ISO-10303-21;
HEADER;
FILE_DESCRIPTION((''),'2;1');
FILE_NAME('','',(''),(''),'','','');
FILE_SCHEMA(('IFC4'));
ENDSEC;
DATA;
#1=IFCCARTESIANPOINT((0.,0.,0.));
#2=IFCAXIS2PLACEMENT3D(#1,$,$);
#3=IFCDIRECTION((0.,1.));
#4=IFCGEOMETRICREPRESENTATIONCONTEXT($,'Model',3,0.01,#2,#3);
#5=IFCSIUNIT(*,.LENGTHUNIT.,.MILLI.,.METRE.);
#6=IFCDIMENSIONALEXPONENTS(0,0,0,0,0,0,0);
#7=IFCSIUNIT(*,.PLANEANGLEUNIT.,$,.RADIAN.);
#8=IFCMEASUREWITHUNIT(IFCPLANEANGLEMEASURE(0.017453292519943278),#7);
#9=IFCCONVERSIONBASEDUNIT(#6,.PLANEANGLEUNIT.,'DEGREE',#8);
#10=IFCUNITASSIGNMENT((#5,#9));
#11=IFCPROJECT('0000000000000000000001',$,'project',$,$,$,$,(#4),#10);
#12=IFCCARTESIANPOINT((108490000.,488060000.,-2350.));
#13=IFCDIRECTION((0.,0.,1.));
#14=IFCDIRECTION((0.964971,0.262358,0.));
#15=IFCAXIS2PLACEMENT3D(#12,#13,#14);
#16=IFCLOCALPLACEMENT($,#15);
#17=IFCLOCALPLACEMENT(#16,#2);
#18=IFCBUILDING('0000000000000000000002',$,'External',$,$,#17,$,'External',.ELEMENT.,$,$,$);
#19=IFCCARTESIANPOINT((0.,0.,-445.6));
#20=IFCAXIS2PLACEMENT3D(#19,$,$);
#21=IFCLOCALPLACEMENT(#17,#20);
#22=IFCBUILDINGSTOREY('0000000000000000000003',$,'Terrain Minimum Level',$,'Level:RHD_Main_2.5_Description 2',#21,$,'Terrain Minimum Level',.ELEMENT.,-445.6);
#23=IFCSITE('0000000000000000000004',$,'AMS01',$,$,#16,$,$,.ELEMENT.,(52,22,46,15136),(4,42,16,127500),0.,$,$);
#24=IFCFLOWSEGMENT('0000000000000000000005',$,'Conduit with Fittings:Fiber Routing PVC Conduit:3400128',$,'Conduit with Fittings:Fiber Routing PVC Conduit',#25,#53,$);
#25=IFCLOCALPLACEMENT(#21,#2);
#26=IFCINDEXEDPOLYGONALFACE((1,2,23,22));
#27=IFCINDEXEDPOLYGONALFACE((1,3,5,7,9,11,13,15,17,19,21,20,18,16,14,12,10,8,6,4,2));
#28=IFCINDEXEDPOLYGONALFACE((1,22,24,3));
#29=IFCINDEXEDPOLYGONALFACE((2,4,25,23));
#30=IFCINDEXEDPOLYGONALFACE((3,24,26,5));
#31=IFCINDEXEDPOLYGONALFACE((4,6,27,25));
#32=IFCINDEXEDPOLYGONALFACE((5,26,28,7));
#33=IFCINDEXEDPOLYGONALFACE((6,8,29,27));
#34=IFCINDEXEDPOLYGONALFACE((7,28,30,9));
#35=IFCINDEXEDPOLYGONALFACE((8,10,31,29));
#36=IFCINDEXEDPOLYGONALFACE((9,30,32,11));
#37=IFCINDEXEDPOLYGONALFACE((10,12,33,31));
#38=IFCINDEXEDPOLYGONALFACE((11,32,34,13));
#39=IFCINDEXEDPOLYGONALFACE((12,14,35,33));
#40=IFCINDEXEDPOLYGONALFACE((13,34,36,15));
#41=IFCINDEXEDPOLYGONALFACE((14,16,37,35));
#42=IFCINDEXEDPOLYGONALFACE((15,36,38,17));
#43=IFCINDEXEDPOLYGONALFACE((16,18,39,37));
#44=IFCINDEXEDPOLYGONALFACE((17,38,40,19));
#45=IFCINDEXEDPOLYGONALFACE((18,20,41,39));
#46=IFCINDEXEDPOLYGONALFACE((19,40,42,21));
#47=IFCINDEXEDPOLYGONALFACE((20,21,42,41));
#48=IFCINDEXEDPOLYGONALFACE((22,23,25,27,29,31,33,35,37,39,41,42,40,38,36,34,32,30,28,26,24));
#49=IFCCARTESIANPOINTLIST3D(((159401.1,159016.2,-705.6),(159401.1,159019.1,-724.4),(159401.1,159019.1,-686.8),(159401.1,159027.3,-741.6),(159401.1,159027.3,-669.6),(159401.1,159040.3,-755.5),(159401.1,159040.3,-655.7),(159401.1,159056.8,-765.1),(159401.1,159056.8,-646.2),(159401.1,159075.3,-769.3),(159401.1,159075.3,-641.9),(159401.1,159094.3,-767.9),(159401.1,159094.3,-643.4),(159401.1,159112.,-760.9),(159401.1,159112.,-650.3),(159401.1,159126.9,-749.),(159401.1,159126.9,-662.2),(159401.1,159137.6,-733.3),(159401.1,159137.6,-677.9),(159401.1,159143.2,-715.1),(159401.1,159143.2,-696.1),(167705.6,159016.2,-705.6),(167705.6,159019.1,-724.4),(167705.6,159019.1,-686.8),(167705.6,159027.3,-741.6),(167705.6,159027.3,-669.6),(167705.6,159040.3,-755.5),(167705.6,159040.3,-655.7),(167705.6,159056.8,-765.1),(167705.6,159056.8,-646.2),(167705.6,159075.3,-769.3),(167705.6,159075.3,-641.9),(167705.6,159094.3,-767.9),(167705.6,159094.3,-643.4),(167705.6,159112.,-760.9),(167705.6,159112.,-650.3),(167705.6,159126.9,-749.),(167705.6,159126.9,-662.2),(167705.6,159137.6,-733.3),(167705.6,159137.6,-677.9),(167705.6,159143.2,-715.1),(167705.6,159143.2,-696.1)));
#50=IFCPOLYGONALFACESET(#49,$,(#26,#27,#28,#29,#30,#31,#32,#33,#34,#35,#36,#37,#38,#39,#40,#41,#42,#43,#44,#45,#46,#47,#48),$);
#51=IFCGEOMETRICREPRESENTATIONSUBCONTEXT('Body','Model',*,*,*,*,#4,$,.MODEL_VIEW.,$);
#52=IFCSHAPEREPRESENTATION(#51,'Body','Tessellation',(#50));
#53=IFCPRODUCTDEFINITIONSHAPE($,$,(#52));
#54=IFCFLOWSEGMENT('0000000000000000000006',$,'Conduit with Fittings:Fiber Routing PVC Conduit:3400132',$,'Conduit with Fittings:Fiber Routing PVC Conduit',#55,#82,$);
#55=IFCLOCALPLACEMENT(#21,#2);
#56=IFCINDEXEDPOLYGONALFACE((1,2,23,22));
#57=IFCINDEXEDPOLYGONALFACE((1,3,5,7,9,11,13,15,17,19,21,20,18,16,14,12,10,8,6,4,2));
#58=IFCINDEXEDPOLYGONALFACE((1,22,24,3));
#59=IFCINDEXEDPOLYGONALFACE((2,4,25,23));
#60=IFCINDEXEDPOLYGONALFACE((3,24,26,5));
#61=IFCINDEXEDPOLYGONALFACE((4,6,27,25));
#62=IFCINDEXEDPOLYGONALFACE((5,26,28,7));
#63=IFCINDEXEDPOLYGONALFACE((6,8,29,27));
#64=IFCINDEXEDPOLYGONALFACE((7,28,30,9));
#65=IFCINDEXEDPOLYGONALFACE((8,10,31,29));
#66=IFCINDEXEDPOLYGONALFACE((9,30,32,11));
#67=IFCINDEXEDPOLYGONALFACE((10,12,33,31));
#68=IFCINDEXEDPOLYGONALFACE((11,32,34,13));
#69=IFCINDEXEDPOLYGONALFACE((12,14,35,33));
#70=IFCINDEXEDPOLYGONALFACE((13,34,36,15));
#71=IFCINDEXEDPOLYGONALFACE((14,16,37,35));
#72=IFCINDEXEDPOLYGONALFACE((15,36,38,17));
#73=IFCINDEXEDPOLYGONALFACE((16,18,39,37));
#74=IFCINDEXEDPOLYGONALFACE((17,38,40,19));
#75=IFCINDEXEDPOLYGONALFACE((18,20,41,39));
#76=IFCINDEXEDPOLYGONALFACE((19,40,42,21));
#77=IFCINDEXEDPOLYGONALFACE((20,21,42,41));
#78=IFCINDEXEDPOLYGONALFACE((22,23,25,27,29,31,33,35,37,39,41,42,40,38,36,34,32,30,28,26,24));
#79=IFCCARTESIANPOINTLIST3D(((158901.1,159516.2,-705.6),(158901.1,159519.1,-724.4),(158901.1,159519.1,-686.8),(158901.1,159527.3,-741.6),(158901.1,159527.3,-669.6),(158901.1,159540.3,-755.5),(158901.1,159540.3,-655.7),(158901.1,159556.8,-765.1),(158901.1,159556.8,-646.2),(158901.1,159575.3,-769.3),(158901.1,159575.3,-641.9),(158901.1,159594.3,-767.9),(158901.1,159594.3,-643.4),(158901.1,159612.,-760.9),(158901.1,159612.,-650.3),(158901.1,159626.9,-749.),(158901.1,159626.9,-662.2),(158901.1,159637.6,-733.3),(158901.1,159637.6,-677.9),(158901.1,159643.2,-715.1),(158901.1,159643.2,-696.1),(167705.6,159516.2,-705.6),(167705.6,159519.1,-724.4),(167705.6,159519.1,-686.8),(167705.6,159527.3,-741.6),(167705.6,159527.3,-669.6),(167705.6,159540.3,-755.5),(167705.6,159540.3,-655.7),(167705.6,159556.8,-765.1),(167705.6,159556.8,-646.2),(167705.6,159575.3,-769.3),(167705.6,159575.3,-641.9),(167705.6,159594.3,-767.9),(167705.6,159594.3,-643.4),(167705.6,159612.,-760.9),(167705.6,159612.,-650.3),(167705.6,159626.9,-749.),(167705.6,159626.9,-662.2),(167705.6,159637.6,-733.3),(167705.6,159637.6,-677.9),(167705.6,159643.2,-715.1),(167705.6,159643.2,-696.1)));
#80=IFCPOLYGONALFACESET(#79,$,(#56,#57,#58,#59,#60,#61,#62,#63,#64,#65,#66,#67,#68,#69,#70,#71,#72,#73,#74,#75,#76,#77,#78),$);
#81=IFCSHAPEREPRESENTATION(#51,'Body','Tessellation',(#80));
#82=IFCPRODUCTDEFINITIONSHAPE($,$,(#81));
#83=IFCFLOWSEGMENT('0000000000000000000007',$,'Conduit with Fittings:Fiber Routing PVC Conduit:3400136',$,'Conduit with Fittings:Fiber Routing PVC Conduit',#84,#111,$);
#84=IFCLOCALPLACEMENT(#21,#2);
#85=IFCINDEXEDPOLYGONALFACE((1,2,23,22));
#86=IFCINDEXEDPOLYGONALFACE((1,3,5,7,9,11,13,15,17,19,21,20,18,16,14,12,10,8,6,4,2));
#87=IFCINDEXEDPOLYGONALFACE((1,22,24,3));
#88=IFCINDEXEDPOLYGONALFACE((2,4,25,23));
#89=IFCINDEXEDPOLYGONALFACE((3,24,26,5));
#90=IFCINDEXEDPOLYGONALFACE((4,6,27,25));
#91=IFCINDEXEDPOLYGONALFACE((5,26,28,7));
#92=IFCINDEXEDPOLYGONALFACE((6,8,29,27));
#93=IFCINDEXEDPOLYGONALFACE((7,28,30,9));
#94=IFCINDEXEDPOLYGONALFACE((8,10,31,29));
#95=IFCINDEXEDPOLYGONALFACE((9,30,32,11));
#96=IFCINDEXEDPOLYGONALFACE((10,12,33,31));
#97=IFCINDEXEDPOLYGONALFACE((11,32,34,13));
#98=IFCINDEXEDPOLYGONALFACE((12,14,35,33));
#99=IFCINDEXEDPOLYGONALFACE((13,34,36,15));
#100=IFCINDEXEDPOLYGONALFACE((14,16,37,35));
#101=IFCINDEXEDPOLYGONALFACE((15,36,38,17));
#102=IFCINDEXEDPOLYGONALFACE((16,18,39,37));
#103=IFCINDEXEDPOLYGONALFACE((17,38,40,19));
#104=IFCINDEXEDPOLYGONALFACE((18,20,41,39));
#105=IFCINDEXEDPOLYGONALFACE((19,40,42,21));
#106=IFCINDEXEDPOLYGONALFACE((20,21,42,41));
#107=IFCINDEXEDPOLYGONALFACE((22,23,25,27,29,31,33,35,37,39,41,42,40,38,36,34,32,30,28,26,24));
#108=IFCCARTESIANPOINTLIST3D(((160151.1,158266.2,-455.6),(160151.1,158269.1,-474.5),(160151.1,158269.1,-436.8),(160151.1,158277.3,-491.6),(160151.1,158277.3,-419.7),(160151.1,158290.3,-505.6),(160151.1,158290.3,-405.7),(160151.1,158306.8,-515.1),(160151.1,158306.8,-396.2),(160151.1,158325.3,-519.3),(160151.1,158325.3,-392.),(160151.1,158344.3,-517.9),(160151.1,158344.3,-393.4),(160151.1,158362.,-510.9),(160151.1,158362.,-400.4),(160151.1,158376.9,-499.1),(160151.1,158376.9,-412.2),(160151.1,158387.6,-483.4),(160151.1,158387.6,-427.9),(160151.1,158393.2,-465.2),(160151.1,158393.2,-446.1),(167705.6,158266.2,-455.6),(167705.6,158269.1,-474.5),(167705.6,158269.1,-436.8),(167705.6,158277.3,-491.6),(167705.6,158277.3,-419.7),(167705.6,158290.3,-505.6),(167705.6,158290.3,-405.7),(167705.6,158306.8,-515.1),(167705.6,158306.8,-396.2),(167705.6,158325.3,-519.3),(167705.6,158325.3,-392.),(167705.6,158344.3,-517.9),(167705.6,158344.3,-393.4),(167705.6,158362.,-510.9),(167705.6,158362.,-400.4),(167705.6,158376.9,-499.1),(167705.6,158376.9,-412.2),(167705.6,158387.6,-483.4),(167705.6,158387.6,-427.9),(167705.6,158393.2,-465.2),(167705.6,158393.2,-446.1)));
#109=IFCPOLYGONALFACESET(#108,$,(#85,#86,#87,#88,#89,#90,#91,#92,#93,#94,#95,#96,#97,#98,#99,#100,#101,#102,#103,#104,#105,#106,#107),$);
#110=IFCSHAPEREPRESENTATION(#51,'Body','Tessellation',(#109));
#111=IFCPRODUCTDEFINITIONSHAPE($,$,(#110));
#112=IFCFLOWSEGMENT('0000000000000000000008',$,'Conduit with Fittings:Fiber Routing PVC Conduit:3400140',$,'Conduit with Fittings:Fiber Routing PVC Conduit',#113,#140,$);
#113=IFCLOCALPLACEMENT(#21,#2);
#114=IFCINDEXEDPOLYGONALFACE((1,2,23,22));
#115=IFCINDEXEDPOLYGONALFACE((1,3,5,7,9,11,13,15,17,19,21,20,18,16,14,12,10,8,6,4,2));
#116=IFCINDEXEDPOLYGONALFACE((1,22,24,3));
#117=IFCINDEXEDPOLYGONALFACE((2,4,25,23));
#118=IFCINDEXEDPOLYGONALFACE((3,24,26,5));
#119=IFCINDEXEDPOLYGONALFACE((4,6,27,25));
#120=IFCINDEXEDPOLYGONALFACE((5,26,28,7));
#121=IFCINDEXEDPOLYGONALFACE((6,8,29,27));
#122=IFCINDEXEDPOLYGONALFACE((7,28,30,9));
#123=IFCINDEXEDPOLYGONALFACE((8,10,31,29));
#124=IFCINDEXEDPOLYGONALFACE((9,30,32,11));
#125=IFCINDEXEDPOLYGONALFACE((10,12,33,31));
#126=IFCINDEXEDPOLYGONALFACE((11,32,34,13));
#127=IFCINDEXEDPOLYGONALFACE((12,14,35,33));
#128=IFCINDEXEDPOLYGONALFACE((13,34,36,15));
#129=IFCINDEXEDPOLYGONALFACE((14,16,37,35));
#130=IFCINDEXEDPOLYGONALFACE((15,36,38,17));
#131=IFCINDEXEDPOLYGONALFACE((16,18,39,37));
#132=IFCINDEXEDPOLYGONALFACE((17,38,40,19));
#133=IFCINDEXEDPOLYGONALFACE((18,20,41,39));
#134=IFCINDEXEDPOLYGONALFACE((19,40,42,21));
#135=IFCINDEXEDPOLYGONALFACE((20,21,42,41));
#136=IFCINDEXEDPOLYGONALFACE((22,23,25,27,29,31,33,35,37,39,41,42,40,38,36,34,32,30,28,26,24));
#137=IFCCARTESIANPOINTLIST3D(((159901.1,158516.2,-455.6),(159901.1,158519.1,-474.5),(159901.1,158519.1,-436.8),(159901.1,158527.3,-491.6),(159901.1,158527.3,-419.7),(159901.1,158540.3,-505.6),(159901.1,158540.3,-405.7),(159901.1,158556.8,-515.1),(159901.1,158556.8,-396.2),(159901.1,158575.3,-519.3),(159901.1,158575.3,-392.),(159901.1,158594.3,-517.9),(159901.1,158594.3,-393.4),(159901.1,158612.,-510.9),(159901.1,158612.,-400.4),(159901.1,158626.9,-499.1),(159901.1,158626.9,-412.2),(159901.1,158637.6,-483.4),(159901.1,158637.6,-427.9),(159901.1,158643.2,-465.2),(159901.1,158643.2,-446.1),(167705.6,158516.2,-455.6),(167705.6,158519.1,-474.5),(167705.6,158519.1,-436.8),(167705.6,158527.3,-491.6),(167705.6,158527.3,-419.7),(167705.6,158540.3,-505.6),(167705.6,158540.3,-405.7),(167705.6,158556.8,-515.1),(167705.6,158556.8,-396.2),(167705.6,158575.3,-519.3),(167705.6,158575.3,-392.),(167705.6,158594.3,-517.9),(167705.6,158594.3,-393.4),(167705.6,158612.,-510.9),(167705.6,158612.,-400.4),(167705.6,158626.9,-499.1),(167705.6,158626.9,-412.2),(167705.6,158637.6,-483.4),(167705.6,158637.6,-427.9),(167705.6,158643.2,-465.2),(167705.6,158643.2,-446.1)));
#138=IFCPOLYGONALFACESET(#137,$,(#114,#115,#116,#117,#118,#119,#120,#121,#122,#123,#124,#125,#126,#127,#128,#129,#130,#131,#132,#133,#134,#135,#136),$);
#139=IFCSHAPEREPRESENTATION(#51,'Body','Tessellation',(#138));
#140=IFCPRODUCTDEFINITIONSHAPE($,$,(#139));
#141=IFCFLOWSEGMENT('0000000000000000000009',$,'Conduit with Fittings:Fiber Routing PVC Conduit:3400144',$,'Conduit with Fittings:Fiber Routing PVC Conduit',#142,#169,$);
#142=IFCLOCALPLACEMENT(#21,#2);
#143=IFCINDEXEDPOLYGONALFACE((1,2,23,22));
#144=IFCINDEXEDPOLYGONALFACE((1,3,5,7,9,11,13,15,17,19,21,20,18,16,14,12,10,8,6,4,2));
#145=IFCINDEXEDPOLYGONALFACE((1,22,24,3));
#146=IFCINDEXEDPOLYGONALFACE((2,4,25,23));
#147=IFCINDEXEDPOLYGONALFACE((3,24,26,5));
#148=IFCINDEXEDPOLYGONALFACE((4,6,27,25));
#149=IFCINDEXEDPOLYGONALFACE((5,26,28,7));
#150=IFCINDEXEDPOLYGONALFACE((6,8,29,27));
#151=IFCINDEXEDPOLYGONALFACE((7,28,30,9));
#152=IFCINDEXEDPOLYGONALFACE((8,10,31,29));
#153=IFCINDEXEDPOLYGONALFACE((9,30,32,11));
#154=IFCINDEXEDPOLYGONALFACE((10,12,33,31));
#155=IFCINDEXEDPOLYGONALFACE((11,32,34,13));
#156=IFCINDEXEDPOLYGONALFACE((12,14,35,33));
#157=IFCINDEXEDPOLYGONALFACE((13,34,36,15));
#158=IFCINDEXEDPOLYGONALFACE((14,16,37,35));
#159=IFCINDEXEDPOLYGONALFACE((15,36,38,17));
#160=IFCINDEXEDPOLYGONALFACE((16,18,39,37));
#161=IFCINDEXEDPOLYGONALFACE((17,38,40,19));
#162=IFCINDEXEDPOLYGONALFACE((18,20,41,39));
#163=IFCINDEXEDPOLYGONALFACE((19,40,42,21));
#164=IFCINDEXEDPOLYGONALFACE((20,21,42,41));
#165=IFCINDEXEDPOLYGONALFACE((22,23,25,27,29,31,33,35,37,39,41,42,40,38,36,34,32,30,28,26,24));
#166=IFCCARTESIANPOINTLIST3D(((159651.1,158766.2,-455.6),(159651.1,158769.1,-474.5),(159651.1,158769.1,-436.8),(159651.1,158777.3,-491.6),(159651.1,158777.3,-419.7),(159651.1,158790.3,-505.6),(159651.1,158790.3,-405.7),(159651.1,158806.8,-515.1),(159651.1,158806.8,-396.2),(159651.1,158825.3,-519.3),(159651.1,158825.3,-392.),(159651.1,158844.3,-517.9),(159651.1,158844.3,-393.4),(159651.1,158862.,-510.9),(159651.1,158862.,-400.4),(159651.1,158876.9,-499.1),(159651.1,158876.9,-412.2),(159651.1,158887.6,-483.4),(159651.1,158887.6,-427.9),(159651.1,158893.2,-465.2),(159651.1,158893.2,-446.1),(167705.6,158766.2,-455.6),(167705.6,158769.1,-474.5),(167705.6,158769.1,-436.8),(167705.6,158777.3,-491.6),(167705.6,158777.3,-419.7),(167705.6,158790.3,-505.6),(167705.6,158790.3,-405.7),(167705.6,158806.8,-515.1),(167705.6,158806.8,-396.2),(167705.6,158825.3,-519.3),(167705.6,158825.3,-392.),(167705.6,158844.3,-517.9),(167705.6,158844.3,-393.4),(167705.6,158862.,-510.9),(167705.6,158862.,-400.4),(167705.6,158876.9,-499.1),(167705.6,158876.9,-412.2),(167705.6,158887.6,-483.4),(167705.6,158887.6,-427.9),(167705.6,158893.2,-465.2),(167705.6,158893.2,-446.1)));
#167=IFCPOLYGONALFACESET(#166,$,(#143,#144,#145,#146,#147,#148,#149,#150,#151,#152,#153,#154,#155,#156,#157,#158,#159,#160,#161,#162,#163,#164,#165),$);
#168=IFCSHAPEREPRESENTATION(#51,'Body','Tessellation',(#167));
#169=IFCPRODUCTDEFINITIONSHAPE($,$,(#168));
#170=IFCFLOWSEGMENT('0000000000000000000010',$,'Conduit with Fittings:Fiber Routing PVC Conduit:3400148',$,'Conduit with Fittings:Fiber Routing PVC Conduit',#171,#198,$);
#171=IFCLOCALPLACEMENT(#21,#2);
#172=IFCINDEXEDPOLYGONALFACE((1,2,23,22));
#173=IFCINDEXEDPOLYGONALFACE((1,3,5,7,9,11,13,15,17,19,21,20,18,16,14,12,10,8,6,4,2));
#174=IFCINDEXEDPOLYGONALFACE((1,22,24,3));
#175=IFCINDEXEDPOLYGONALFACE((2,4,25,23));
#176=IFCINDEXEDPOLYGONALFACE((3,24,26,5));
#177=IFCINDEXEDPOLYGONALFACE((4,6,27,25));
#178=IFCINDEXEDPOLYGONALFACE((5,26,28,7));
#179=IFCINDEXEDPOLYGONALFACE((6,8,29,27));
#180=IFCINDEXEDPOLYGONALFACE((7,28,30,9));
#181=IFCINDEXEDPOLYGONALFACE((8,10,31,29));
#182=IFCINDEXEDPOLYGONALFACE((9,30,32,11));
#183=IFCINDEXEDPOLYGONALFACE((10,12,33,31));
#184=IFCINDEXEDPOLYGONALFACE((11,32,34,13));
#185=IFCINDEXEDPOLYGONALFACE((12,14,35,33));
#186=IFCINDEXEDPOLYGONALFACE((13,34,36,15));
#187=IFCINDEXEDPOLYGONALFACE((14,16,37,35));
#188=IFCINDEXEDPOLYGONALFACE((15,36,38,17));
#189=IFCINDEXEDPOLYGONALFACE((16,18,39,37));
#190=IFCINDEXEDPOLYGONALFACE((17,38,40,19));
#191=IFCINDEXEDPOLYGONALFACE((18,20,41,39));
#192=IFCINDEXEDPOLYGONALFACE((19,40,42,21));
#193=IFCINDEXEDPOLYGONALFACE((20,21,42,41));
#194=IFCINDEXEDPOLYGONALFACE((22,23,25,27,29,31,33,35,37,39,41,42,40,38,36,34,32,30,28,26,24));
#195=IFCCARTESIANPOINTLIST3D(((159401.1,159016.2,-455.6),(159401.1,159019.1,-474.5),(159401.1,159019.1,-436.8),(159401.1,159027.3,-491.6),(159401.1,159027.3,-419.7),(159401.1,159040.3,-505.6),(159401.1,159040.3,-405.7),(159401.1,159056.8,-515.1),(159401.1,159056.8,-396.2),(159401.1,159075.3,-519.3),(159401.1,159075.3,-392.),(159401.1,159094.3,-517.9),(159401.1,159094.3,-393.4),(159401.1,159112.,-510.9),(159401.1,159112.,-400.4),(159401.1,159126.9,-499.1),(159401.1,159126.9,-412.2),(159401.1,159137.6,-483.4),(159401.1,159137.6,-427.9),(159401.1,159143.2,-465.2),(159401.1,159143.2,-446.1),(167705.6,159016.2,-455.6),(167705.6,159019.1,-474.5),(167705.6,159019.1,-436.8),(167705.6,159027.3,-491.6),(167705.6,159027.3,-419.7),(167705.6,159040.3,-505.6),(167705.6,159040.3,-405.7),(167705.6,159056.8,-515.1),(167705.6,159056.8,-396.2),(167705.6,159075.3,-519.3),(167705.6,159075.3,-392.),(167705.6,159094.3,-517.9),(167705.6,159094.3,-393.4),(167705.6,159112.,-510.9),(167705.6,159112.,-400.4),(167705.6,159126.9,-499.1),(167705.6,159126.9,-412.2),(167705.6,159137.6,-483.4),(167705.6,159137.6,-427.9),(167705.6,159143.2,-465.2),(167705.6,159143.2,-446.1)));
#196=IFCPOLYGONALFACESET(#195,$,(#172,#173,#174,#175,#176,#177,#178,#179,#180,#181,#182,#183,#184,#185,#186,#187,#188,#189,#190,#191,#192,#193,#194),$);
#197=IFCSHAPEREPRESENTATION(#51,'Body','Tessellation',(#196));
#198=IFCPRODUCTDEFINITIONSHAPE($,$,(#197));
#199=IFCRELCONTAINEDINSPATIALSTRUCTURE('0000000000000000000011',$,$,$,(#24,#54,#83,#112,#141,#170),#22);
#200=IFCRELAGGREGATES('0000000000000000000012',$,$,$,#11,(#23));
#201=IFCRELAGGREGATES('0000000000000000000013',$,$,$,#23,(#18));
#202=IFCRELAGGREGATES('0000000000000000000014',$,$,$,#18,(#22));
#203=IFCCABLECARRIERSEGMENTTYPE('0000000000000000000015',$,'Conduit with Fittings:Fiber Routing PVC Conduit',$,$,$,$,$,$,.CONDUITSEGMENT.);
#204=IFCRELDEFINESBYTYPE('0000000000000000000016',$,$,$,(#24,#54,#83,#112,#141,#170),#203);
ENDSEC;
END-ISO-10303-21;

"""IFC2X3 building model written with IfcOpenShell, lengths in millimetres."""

from ifc_helpers import new_model, entity, si_unit, converted_unit, direction, frame, frame_2d, origin, place, context, subcontext, project, spatial, circle, extrude, type_object, element, save


model = new_model("IFC2X3")

# Units and contexts
model_context = context("Model", 3, precision=0.01, world=origin(), true_north=direction((0.0, 1.0)))
body_context = subcontext(model_context, "Body", "Model", "MODEL_VIEW")
ifc_project = project(units=[si_unit("LENGTHUNIT", "METRE", prefix="MILLI"), converted_unit("PLANEANGLEUNIT", "DEGREE", entity("IfcPlaneAngleMeasure", 0.017453292519943278), si_unit("PLANEANGLEUNIT", "RADIAN"), dimensions=[0, 0, 0, 0, 0, 0, 0])], contexts=[model_context])

# Site, building, storey
site_placement = place(None, frame((108490000.0, 488060000.0, -2350.0), z_axis=(0.0, 0.0, 1.0), x_axis=(0.964971, 0.262358, 0.0)))
site = spatial("IfcSite", under=ifc_project, at=site_placement, Name="AMS01", CompositionType="ELEMENT", RefLatitude=(52, 22, 46, 15136), RefLongitude=(4, 42, 16, 127500), RefElevation=0.0)
building_placement = place(site_placement, origin())
building = spatial("IfcBuilding", under=site, at=building_placement, Name="External", LongName="External", CompositionType="ELEMENT")
storey_placement = place(building_placement, frame((0.0, 0.0, -445.6)))
storey = spatial("IfcBuildingStorey", under=building, at=storey_placement, Name="Terrain Minimum Level", ObjectType="Level:RHD_Main_2.5_Description 2", LongName="Terrain Minimum Level", CompositionType="ELEMENT", Elevation=-445.6)

# Flow segments
cable_carrier_segment_type = type_object("IfcCableCarrierSegmentType", Name="Conduit with Fittings:Fiber Routing PVC Conduit", PredefinedType="CONDUITSEGMENT")
flow_segment_1_placement = place(storey_placement, origin())
element("IfcFlowSegment", 1, at=flow_segment_1_placement, inside=storey, type_object=cable_carrier_segment_type, Name="Conduit with Fittings:Fiber Routing PVC Conduit:3400128", ObjectType="Conduit with Fittings:Fiber Routing PVC Conduit", context=body_context, shape_type="SweptSolid", body=[
    extrude(circle(Radius=63.9, at=frame_2d((0.0, 0.0), x_axis=(1.0, 0.0))), frame((159401.1, 159080.1, -705.6), z_axis=(1.0, 0.0, 0.0), x_axis=(0.0, -1.0, 0.0)), (0.0, 0.0, 1.0), 8304.6),
])
flow_segment_2_placement = place(storey_placement, origin())
element("IfcFlowSegment", 2, at=flow_segment_2_placement, inside=storey, type_object=cable_carrier_segment_type, Name="Conduit with Fittings:Fiber Routing PVC Conduit:3400132", ObjectType="Conduit with Fittings:Fiber Routing PVC Conduit", context=body_context, shape_type="SweptSolid", body=[
    extrude(circle(Radius=63.9, at=frame_2d((0.0, 0.0), x_axis=(1.0, 0.0))), frame((158901.1, 159580.1, -705.6), z_axis=(1.0, 0.0, 0.0), x_axis=(0.0, -1.0, 0.0)), (0.0, 0.0, 1.0), 8804.6),
])
flow_segment_3_placement = place(storey_placement, origin())
element("IfcFlowSegment", 3, at=flow_segment_3_placement, inside=storey, type_object=cable_carrier_segment_type, Name="Conduit with Fittings:Fiber Routing PVC Conduit:3400136", ObjectType="Conduit with Fittings:Fiber Routing PVC Conduit", context=body_context, shape_type="SweptSolid", body=[
    extrude(circle(Radius=63.9, at=frame_2d((0.0, 0.0), x_axis=(1.0, 0.0))), frame((160151.1, 158330.1, -455.6), z_axis=(1.0, 0.0, 0.0), x_axis=(0.0, -1.0, 0.0)), (0.0, 0.0, 1.0), 7554.6),
])
flow_segment_4_placement = place(storey_placement, origin())
element("IfcFlowSegment", 4, at=flow_segment_4_placement, inside=storey, type_object=cable_carrier_segment_type, Name="Conduit with Fittings:Fiber Routing PVC Conduit:3400140", ObjectType="Conduit with Fittings:Fiber Routing PVC Conduit", context=body_context, shape_type="SweptSolid", body=[
    extrude(circle(Radius=63.9, at=frame_2d((0.0, 0.0), x_axis=(1.0, 0.0))), frame((159901.1, 158580.1, -455.6), z_axis=(1.0, 0.0, 0.0), x_axis=(0.0, -1.0, 0.0)), (0.0, 0.0, 1.0), 7804.6),
])
flow_segment_5_placement = place(storey_placement, origin())
element("IfcFlowSegment", 5, at=flow_segment_5_placement, inside=storey, type_object=cable_carrier_segment_type, Name="Conduit with Fittings:Fiber Routing PVC Conduit:3400144", ObjectType="Conduit with Fittings:Fiber Routing PVC Conduit", context=body_context, shape_type="SweptSolid", body=[
    extrude(circle(Radius=63.9, at=frame_2d((0.0, 0.0), x_axis=(1.0, 0.0))), frame((159651.1, 158830.1, -455.6), z_axis=(1.0, 0.0, 0.0), x_axis=(0.0, -1.0, 0.0)), (0.0, 0.0, 1.0), 8054.6),
])
flow_segment_6_placement = place(storey_placement, origin())
element("IfcFlowSegment", 6, at=flow_segment_6_placement, inside=storey, type_object=cable_carrier_segment_type, Name="Conduit with Fittings:Fiber Routing PVC Conduit:3400148", ObjectType="Conduit with Fittings:Fiber Routing PVC Conduit", context=body_context, shape_type="SweptSolid", body=[
    extrude(circle(Radius=63.9, at=frame_2d((0.0, 0.0), x_axis=(1.0, 0.0))), frame((159401.1, 159080.1, -455.6), z_axis=(1.0, 0.0, 0.0), x_axis=(0.0, -1.0, 0.0)), (0.0, 0.0, 1.0), 8304.6),
])

save(model, "model.ifc")
